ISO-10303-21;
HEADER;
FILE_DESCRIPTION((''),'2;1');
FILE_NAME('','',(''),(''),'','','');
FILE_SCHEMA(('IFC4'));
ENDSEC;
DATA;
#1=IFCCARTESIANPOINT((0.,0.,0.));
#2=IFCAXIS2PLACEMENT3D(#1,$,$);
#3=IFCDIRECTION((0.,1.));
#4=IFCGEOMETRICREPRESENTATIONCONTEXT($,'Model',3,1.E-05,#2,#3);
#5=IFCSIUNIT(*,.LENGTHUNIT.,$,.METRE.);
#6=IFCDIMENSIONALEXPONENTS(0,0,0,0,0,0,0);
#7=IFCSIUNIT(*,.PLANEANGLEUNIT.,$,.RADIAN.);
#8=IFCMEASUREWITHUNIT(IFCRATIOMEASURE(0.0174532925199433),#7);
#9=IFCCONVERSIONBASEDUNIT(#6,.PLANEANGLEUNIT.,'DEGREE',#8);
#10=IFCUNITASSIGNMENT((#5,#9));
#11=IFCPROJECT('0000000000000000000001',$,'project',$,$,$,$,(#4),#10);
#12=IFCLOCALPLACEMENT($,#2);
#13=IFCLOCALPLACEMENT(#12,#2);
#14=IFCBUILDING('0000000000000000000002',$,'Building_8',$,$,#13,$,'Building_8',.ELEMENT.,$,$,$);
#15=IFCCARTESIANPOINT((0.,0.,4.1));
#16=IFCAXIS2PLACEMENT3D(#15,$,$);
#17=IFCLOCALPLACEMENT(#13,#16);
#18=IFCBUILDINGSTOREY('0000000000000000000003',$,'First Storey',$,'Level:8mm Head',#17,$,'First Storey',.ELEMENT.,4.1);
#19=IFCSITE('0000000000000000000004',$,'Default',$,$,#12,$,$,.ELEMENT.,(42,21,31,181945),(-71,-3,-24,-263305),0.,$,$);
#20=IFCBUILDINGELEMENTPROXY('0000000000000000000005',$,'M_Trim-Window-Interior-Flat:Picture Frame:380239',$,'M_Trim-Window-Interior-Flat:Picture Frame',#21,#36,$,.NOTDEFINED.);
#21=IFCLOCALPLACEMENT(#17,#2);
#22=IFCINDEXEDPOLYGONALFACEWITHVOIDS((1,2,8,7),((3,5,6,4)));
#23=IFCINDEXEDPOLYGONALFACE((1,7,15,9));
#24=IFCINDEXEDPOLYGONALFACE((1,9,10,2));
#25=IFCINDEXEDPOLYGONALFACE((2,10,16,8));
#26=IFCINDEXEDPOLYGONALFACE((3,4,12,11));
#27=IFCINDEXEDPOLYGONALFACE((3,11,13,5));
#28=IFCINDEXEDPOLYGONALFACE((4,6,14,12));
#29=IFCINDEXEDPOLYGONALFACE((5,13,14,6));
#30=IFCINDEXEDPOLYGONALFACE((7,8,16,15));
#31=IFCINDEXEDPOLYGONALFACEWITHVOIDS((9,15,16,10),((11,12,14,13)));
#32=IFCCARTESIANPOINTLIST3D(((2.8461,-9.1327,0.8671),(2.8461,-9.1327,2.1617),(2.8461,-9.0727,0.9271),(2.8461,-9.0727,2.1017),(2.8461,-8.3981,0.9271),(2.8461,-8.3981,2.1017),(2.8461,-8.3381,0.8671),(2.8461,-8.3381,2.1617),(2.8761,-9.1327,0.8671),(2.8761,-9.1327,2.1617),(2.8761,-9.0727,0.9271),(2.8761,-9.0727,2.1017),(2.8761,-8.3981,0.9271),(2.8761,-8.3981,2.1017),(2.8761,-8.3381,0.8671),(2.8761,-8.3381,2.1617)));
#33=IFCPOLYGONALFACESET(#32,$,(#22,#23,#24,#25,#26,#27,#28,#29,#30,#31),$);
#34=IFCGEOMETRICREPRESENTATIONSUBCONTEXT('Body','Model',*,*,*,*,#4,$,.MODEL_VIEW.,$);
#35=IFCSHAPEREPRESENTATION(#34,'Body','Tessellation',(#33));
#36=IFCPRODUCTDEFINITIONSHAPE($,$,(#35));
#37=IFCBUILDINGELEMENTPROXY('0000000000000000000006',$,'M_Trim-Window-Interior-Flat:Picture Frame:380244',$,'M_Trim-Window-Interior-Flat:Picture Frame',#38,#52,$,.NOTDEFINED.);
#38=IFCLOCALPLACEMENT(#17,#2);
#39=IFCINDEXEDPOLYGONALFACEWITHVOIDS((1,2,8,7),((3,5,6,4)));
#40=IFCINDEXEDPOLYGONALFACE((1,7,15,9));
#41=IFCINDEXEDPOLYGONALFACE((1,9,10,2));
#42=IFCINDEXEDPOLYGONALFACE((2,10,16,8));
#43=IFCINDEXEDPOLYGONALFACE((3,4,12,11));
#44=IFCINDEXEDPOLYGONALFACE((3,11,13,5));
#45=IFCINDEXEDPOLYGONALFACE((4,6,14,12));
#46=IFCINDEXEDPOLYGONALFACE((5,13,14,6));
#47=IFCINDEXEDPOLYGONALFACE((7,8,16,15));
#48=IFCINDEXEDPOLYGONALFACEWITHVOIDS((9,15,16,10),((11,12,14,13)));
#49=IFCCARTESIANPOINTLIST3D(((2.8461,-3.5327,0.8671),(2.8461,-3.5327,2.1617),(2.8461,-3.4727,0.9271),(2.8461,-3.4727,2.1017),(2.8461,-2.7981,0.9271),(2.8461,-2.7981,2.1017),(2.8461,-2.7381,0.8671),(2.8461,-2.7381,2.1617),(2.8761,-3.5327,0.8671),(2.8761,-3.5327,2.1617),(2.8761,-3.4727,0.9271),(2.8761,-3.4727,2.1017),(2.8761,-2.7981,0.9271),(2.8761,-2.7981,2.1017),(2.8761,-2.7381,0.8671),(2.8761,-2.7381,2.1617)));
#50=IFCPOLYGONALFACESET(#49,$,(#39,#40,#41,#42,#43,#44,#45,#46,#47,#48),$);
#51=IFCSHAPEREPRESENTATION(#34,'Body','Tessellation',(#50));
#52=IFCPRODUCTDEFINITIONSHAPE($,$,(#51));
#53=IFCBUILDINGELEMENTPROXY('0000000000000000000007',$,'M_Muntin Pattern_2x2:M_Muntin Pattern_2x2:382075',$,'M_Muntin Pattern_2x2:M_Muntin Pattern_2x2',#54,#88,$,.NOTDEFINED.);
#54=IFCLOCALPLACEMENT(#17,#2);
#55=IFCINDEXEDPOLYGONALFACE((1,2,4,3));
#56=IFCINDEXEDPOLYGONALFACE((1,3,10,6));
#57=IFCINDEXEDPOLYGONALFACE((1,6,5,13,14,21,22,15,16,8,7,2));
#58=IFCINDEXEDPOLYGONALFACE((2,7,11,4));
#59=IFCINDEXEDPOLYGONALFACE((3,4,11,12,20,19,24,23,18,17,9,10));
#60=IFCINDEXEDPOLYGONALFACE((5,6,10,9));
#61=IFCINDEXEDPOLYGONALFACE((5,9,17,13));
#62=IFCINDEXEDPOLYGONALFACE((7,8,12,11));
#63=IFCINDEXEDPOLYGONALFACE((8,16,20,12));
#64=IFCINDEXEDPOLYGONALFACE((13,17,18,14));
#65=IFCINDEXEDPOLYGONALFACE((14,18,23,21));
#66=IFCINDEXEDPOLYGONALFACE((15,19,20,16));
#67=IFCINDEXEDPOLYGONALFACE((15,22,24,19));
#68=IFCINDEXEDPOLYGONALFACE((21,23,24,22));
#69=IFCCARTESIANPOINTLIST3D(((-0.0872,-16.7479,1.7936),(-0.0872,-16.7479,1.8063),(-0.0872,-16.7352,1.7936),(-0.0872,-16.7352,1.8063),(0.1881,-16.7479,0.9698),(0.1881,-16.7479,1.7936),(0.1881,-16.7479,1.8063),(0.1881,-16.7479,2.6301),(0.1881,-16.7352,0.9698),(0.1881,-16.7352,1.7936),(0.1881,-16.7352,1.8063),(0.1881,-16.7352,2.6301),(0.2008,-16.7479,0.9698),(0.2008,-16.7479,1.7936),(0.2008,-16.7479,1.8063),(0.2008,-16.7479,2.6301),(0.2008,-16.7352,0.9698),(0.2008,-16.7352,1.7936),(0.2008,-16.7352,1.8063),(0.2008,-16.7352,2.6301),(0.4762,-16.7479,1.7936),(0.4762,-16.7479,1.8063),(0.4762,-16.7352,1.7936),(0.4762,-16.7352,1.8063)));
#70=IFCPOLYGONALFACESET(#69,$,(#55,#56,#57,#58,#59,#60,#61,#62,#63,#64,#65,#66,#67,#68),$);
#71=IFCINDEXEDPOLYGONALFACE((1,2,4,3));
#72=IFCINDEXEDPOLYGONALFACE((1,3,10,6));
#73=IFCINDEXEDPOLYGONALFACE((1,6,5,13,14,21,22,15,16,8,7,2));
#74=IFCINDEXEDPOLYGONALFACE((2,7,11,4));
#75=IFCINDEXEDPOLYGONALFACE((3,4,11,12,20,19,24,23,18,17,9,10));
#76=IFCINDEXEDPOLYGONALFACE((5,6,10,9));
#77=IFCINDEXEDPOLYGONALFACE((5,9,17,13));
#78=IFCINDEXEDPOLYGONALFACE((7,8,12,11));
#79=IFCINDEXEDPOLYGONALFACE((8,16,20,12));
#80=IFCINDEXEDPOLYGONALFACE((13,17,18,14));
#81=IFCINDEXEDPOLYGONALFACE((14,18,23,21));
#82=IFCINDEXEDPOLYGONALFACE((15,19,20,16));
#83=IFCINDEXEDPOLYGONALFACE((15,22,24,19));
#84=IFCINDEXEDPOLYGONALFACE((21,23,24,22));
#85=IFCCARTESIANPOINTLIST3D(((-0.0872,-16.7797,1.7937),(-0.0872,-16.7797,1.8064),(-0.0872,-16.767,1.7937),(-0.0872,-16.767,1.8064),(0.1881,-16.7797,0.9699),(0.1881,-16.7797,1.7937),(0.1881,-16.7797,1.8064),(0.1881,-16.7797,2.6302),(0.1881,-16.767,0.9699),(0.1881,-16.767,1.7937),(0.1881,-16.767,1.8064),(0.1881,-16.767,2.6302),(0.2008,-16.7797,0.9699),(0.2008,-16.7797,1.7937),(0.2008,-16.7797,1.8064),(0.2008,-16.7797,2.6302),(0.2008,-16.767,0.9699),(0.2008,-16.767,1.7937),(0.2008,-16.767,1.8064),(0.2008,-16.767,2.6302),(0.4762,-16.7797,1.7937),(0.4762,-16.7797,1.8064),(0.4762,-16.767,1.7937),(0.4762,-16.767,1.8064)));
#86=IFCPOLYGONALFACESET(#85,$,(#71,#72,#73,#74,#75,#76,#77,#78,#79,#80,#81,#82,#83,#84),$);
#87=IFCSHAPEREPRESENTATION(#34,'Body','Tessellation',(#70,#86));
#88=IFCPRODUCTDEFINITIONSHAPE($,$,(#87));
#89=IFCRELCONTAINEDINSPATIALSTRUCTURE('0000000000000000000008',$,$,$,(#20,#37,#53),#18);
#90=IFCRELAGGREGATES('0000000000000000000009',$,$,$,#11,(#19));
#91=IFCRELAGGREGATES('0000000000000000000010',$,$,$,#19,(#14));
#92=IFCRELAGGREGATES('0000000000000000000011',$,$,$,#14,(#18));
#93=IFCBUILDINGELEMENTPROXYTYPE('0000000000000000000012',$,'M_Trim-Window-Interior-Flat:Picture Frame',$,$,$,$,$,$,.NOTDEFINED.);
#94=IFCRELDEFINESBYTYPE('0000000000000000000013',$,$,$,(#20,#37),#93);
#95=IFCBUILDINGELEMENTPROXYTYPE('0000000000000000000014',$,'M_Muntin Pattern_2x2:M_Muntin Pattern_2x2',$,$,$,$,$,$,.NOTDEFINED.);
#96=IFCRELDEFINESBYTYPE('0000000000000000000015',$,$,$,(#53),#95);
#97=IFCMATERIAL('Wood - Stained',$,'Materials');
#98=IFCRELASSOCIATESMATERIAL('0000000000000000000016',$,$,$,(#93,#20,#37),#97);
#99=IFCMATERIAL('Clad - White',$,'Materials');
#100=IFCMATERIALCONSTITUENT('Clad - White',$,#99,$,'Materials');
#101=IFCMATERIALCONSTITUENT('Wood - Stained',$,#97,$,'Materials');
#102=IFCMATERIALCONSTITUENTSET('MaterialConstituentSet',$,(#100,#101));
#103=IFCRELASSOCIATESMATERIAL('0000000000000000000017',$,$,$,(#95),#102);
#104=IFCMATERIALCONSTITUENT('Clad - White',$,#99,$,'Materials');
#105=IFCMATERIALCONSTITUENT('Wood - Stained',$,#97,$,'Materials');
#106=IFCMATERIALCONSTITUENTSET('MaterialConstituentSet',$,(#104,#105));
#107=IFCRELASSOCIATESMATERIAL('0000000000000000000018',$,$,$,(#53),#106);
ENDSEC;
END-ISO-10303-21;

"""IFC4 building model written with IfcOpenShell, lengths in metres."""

from ifc_helpers import new_model, entity, si_unit, converted_unit, direction, frame, origin, place, context, subcontext, project, spatial, indexed_curve, outline, extrude, source, transform, mapped, material, constituent, constituent_set, type_object, type_shapes, element, save


model = new_model("IFC4")

# Units and contexts
model_context = context("Model", 3, precision=1e-05, world=origin(), true_north=direction((0.0, 1.0)))
body_context = subcontext(model_context, "Body", "Model", "MODEL_VIEW")
ifc_project = project(units=[si_unit("LENGTHUNIT", "METRE"), converted_unit("PLANEANGLEUNIT", "DEGREE", entity("IfcRatioMeasure", 0.0174532925199433), si_unit("PLANEANGLEUNIT", "RADIAN"), dimensions=[0, 0, 0, 0, 0, 0, 0])], contexts=[model_context])

# Site, building, storey
site_placement = place(None, origin())
site = spatial("IfcSite", under=ifc_project, at=site_placement, Name="Default", CompositionType="ELEMENT", RefLatitude=(42, 21, 31, 181945), RefLongitude=(-71, -3, -24, -263305), RefElevation=0.0)
building_placement = place(site_placement, origin())
building = spatial("IfcBuilding", under=site, at=building_placement, Name="Building_8", LongName="Building_8", CompositionType="ELEMENT")
storey_placement = place(building_placement, frame((0.0, 0.0, 4.1)))
storey = spatial("IfcBuildingStorey", under=building, at=storey_placement, Name="First Storey", ObjectType="Level:8mm Head", LongName="First Storey", CompositionType="ELEMENT", Elevation=4.1)

# Shared definitions
ifc_material_1 = material(Name="Clad - White", Category="Materials")
ifc_material_2 = material(Name="Wood - Stained", Category="Materials")

# Building element proxies
building_element_proxy_type_1 = type_object("IfcBuildingElementProxyType", Name="M_Trim-Window-Interior-Flat:Picture Frame", PredefinedType="NOTDEFINED", material=ifc_material_2)
shared_shape_1 = source(origin(), body_context, "Body", "SweptSolid", [
    extrude(outline(indexed_curve([(-0.3973, -0.6473), (0.3973, -0.6473), (0.3973, 0.6473), (-0.3973, 0.6473), (-0.3973, -0.6473)], self_intersect=False), holes=[indexed_curve([(-0.3373, -0.5873), (-0.3373, 0.5873), (0.3373, 0.5873), (0.3373, -0.5873), (-0.3373, -0.5873)], self_intersect=False)]), frame((0.0, -0.6, 0.0), z_axis=(0.0, 0.0, 1.0), x_axis=(-1.0, 0.0, 0.0)), (0.0, 0.0, 1.0), 0.03),
])
type_shapes(building_element_proxy_type_1, [shared_shape_1])
for number, where, z_axis, x_axis, name in (
    (1, (2.8461, -8.7354, 2.1144), (1.0, 0.0, 0.0), (0.0, 1.0, 0.0), "M_Trim-Window-Interior-Flat:Picture Frame:380239"),
    (2, (2.8461, -3.1354, 2.1144), (1.0, 0.0, 0.0), (0.0, 1.0, 0.0), "M_Trim-Window-Interior-Flat:Picture Frame:380244"),
):
    element("IfcBuildingElementProxy", number, at=place(storey_placement, frame(where, z_axis=z_axis, x_axis=x_axis)), inside=storey, type_object=building_element_proxy_type_1, material=ifc_material_2, Name=name, ObjectType="M_Trim-Window-Interior-Flat:Picture Frame", PredefinedType="NOTDEFINED", context=body_context, shape_type="MappedRepresentation", body=[
        mapped(shared_shape_1, transform((0.0, 0.0, 0.0), scale=1.0)),
    ])
ifc_constituent_1 = constituent(ifc_material_1, Name="Clad - White", Category="Materials")
ifc_constituent_2 = constituent(ifc_material_2, Name="Wood - Stained", Category="Materials")
ifc_constituent_set_1 = constituent_set(constituents=[ifc_constituent_1, ifc_constituent_2], Name="MaterialConstituentSet")
ifc_constituent_3 = constituent(ifc_material_1, Name="Clad - White", Category="Materials")
ifc_constituent_4 = constituent(ifc_material_2, Name="Wood - Stained", Category="Materials")
ifc_constituent_set_2 = constituent_set(constituents=[ifc_constituent_3, ifc_constituent_4], Name="MaterialConstituentSet")
building_element_proxy_type_2 = type_object("IfcBuildingElementProxyType", Name="M_Muntin Pattern_2x2:M_Muntin Pattern_2x2", PredefinedType="NOTDEFINED", material=ifc_constituent_set_2)
shared_shape_2 = source(origin(), body_context, "Body", "SweptSolid", [
    extrude(outline(indexed_curve([(0.0064, -0.0064), (0.8301, -0.0064), (0.8301, 0.0063), (0.0064, 0.0063), (0.0064, 0.2817), (-0.0063, 0.2817), (-0.0063, 0.0063), (-0.8302, 0.0063), (-0.8302, -0.0064), (-0.0063, -0.0064), (-0.0063, -0.2817), (0.0064, -0.2817), (0.0064, -0.0064)], self_intersect=False)), frame((0.0, -0.0222, 0.8301), z_axis=(0.0, 1.0, 0.0), x_axis=(0.0, 0.0, 1.0)), (0.0, 0.0, 1.0), 0.0127),
    extrude(outline(indexed_curve([(0.0064, -0.0064), (0.8302, -0.0064), (0.8302, 0.0063), (0.0064, 0.0063), (0.0064, 0.2817), (-0.0063, 0.2817), (-0.0063, 0.0063), (-0.8302, 0.0063), (-0.8302, -0.0064), (-0.0063, -0.0064), (-0.0063, -0.2817), (0.0064, -0.2817), (0.0064, -0.0064)], self_intersect=False)), frame((0.0, 0.0095, 0.8302), z_axis=(0.0, 1.0, 0.0), x_axis=(0.0, 0.0, 1.0)), (0.0, 0.0, 1.0), 0.0127),
])
type_shapes(building_element_proxy_type_2, [shared_shape_2])
proxy_1_placement = place(storey_placement, frame((0.1945, -16.7575, 0.9699), z_axis=(0.0, 0.0, 1.0), x_axis=(-1.0, 0.0, 0.0)))
element("IfcBuildingElementProxy", 3, at=proxy_1_placement, inside=storey, type_object=building_element_proxy_type_2, material=ifc_constituent_set_1, Name="M_Muntin Pattern_2x2:M_Muntin Pattern_2x2:382075", ObjectType="M_Muntin Pattern_2x2:M_Muntin Pattern_2x2", PredefinedType="NOTDEFINED", context=body_context, shape_type="MappedRepresentation", body=[
    mapped(shared_shape_2, transform((0.0, 0.0, 0.0), scale=1.0)),
])

save(model, "model.ifc")
